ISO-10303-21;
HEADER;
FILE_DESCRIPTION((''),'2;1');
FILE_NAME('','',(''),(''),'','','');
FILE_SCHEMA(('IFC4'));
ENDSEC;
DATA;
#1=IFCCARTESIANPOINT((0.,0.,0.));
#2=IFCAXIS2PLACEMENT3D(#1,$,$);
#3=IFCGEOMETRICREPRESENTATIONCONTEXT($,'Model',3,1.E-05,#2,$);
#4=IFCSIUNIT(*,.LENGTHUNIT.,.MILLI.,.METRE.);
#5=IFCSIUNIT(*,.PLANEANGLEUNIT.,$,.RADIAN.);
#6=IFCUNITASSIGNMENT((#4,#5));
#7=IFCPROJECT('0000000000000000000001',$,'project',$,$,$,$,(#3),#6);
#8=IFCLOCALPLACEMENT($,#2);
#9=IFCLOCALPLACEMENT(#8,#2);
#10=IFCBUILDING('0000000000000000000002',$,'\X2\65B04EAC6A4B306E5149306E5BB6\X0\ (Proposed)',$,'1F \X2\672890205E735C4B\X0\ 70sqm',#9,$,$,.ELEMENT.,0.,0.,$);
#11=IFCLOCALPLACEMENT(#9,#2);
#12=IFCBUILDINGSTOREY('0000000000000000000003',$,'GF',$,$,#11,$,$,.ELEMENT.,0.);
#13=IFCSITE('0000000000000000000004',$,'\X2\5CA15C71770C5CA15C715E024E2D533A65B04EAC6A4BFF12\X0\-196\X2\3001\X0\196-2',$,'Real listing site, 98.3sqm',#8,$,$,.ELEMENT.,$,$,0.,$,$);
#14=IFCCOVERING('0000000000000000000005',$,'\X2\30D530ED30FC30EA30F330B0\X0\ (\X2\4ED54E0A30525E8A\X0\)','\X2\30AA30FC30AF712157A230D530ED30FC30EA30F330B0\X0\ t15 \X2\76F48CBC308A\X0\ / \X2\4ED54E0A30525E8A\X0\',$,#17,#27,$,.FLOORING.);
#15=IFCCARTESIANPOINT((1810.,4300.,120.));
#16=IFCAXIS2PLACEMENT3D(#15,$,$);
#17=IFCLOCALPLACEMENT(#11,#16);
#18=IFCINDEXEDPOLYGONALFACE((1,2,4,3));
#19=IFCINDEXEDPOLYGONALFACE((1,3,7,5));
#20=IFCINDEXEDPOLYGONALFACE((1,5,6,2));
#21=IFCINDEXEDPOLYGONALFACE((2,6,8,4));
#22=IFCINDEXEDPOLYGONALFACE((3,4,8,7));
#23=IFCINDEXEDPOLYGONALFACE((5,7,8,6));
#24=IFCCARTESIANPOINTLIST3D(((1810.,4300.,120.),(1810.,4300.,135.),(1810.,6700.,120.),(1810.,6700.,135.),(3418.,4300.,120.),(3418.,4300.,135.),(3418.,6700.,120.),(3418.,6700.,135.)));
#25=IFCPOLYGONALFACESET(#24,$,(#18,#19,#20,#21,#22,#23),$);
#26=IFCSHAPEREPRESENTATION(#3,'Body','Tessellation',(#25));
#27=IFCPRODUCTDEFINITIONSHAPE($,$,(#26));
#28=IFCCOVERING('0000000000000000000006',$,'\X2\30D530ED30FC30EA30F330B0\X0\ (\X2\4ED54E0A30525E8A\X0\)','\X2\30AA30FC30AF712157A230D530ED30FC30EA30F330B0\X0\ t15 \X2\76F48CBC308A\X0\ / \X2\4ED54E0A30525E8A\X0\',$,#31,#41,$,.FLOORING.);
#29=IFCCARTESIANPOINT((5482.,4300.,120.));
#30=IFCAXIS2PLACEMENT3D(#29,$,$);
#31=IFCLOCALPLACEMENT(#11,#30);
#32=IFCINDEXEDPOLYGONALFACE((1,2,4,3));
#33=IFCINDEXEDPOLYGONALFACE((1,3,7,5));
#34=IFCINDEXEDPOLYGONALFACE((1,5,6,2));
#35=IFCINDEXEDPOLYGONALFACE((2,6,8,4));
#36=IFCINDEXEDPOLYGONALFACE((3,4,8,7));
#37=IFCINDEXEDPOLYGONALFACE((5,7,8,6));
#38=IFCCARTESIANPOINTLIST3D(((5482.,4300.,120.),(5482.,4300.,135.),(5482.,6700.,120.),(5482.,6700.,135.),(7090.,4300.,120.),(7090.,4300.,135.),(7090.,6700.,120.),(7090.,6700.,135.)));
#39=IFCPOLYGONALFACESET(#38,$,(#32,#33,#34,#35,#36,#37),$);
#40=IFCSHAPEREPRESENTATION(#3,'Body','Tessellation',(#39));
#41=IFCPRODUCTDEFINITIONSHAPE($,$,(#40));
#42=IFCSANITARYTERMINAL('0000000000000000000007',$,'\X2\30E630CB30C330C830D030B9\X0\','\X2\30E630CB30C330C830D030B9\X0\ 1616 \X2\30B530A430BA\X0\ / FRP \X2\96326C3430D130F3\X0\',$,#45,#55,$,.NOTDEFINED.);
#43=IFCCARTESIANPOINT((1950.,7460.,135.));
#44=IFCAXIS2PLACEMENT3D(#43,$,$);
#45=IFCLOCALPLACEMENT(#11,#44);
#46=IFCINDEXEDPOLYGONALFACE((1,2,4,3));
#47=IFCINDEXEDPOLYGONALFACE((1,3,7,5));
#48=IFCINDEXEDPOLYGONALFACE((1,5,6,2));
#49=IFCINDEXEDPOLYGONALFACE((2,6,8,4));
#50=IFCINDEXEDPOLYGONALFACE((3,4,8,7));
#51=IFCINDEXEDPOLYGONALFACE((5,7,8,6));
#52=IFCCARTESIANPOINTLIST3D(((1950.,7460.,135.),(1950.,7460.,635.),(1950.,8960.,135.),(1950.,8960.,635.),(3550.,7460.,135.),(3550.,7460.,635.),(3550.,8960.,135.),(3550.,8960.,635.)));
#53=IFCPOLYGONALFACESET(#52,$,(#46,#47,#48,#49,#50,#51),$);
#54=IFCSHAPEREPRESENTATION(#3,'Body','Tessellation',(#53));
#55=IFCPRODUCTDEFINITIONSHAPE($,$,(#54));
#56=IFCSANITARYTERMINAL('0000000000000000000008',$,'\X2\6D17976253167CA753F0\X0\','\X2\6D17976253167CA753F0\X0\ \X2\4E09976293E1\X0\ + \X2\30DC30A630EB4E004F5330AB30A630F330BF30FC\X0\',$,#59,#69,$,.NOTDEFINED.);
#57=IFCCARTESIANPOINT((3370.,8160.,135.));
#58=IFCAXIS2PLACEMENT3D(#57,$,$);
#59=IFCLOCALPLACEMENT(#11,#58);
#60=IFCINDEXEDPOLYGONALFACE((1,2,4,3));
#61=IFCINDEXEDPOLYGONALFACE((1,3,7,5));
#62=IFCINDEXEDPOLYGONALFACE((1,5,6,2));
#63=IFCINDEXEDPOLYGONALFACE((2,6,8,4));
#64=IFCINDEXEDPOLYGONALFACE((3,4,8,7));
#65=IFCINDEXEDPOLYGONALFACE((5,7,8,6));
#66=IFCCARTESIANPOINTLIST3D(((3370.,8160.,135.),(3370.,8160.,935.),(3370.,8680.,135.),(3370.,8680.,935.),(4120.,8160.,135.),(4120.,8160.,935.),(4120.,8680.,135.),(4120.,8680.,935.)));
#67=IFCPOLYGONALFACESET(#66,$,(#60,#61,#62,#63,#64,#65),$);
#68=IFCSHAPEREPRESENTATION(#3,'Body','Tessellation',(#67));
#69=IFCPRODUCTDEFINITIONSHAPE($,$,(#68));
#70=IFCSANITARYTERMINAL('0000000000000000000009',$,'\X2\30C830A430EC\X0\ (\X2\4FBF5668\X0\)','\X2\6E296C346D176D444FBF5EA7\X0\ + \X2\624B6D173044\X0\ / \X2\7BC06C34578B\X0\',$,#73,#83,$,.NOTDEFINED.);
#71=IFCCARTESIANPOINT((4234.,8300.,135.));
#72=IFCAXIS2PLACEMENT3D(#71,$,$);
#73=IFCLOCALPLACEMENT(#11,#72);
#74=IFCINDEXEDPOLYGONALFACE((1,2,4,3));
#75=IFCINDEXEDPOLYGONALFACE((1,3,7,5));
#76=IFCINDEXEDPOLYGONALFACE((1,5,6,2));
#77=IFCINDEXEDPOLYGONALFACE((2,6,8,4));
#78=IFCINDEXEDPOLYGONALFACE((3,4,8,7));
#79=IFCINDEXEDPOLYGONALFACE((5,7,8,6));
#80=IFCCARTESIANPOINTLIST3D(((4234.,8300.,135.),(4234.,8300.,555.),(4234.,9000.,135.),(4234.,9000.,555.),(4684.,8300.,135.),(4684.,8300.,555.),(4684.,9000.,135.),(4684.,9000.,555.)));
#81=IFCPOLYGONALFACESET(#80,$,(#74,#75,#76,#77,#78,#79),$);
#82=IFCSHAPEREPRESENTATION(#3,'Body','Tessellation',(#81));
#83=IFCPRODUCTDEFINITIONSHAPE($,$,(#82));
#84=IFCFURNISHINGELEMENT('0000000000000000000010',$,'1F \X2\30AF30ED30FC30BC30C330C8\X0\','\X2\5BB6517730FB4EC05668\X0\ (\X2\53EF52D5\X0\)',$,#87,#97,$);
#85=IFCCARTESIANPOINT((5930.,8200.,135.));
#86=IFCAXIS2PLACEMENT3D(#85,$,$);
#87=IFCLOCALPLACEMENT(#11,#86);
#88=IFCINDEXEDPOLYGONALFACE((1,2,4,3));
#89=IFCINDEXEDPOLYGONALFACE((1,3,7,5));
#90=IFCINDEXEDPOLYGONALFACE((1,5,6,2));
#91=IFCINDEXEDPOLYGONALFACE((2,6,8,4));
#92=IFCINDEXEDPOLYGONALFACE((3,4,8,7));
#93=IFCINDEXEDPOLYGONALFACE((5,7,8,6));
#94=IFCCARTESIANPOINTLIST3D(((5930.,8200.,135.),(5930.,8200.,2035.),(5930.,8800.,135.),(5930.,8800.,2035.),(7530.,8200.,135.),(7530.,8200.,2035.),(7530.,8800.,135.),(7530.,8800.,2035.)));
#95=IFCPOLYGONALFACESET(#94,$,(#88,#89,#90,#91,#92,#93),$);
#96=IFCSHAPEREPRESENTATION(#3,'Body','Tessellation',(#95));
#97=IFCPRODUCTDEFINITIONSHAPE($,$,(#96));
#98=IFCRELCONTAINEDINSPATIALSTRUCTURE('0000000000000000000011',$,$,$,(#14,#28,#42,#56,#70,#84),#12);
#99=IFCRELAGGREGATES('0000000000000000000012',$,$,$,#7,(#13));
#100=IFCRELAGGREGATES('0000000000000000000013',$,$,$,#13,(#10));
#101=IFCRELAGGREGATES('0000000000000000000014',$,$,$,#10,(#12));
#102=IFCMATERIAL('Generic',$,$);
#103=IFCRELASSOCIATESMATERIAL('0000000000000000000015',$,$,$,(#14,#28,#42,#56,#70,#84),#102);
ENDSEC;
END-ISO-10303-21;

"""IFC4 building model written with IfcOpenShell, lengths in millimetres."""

from ifc_helpers import new_model, si_unit, frame, frame_2d, origin, place, context, project, spatial, rectangle, extrude, material, element, save


model = new_model("IFC4")

# Units and contexts
model_context = context("Model", 3, precision=1e-05, world=origin())
ifc_project = project(units=[si_unit("LENGTHUNIT", "METRE", prefix="MILLI"), si_unit("PLANEANGLEUNIT", "RADIAN")], contexts=[model_context])

# Site, building, storey
site_placement = place(None, origin())
site = spatial("IfcSite", under=ifc_project, at=site_placement, Name="岡山県岡山市中区新京橋２-196、196-2", ObjectType="Real listing site, 98.3sqm", CompositionType="ELEMENT", RefElevation=0.0)
building_placement = place(site_placement, origin())
building = spatial("IfcBuilding", under=site, at=building_placement, Name="新京橋の光の家 (Proposed)", ObjectType="1F 木造平屋 70sqm", CompositionType="ELEMENT", ElevationOfRefHeight=0.0, ElevationOfTerrain=0.0)
storey_placement = place(building_placement, origin())
storey = spatial("IfcBuildingStorey", under=building, at=storey_placement, Name="GF", CompositionType="ELEMENT", Elevation=0.0)

# Coverings
ifc_material_1 = material(Name="Generic")
covering_1_placement = place(storey_placement, frame((1810.0, 4300.0, 120.0)))
element("IfcCovering", 1, at=covering_1_placement, inside=storey, material=ifc_material_1, Name="フローリング (仕上げ床)", Description="オーク無垢フローリング t15 直貼り / 仕上げ床", PredefinedType="FLOORING", context=model_context, shape_type="SweptSolid", body=[
    extrude(rectangle(XDim=1608.0, YDim=2400.0, at=frame_2d((804.0, 1200.0))), frame((1810.0, 4300.0, 120.0)), (0.0, 0.0, 1.0), 15.0),
])
covering_2_placement = place(storey_placement, frame((5482.0, 4300.0, 120.0)))
element("IfcCovering", 2, at=covering_2_placement, inside=storey, material=ifc_material_1, Name="フローリング (仕上げ床)", Description="オーク無垢フローリング t15 直貼り / 仕上げ床", PredefinedType="FLOORING", context=model_context, shape_type="SweptSolid", body=[
    extrude(rectangle(XDim=1608.0, YDim=2400.0, at=frame_2d((804.0, 1200.0))), frame((5482.0, 4300.0, 120.0)), (0.0, 0.0, 1.0), 15.0),
])

# Sanitary terminals
sanitary_terminal_1_placement = place(storey_placement, frame((1950.0, 7460.0, 135.0)))
element("IfcSanitaryTerminal", 3, at=sanitary_terminal_1_placement, inside=storey, material=ifc_material_1, Name="ユニットバス", Description="ユニットバス 1616 サイズ / FRP 防水パン", PredefinedType="NOTDEFINED", context=model_context, shape_type="SweptSolid", body=[
    extrude(rectangle(XDim=1600.0, YDim=1500.0, at=frame_2d((800.0, 750.0))), frame((1950.0, 7460.0, 135.0)), (0.0, 0.0, 1.0), 500.0),
])
sanitary_terminal_2_placement = place(storey_placement, frame((3370.0, 8160.0, 135.0)))
element("IfcSanitaryTerminal", 4, at=sanitary_terminal_2_placement, inside=storey, material=ifc_material_1, Name="洗面化粧台", Description="洗面化粧台 三面鏡 + ボウル一体カウンター", PredefinedType="NOTDEFINED", context=model_context, shape_type="SweptSolid", body=[
    extrude(rectangle(XDim=750.0, YDim=520.0, at=frame_2d((375.0, 260.0))), frame((3370.0, 8160.0, 135.0)), (0.0, 0.0, 1.0), 800.0),
])
sanitary_terminal_3_placement = place(storey_placement, frame((4234.0, 8300.0, 135.0)))
element("IfcSanitaryTerminal", 5, at=sanitary_terminal_3_placement, inside=storey, material=ifc_material_1, Name="トイレ (便器)", Description="温水洗浄便座 + 手洗い / 節水型", PredefinedType="NOTDEFINED", context=model_context, shape_type="SweptSolid", body=[
    extrude(rectangle(XDim=450.0, YDim=700.0, at=frame_2d((225.0, 350.0))), frame((4234.0, 8300.0, 135.0)), (0.0, 0.0, 1.0), 420.0),
])

# Furnishing element
furnishing_placement = place(storey_placement, frame((5930.0, 8200.0, 135.0)))
element("IfcFurnishingElement", 6, at=furnishing_placement, inside=storey, material=ifc_material_1, Name="1F クローゼット", Description="家具・什器 (可動)", context=model_context, shape_type="SweptSolid", body=[
    extrude(rectangle(XDim=1600.0, YDim=600.0, at=frame_2d((800.0, 300.0))), frame((5930.0, 8200.0, 135.0)), (0.0, 0.0, 1.0), 1900.0),
])

save(model, "model.ifc")
